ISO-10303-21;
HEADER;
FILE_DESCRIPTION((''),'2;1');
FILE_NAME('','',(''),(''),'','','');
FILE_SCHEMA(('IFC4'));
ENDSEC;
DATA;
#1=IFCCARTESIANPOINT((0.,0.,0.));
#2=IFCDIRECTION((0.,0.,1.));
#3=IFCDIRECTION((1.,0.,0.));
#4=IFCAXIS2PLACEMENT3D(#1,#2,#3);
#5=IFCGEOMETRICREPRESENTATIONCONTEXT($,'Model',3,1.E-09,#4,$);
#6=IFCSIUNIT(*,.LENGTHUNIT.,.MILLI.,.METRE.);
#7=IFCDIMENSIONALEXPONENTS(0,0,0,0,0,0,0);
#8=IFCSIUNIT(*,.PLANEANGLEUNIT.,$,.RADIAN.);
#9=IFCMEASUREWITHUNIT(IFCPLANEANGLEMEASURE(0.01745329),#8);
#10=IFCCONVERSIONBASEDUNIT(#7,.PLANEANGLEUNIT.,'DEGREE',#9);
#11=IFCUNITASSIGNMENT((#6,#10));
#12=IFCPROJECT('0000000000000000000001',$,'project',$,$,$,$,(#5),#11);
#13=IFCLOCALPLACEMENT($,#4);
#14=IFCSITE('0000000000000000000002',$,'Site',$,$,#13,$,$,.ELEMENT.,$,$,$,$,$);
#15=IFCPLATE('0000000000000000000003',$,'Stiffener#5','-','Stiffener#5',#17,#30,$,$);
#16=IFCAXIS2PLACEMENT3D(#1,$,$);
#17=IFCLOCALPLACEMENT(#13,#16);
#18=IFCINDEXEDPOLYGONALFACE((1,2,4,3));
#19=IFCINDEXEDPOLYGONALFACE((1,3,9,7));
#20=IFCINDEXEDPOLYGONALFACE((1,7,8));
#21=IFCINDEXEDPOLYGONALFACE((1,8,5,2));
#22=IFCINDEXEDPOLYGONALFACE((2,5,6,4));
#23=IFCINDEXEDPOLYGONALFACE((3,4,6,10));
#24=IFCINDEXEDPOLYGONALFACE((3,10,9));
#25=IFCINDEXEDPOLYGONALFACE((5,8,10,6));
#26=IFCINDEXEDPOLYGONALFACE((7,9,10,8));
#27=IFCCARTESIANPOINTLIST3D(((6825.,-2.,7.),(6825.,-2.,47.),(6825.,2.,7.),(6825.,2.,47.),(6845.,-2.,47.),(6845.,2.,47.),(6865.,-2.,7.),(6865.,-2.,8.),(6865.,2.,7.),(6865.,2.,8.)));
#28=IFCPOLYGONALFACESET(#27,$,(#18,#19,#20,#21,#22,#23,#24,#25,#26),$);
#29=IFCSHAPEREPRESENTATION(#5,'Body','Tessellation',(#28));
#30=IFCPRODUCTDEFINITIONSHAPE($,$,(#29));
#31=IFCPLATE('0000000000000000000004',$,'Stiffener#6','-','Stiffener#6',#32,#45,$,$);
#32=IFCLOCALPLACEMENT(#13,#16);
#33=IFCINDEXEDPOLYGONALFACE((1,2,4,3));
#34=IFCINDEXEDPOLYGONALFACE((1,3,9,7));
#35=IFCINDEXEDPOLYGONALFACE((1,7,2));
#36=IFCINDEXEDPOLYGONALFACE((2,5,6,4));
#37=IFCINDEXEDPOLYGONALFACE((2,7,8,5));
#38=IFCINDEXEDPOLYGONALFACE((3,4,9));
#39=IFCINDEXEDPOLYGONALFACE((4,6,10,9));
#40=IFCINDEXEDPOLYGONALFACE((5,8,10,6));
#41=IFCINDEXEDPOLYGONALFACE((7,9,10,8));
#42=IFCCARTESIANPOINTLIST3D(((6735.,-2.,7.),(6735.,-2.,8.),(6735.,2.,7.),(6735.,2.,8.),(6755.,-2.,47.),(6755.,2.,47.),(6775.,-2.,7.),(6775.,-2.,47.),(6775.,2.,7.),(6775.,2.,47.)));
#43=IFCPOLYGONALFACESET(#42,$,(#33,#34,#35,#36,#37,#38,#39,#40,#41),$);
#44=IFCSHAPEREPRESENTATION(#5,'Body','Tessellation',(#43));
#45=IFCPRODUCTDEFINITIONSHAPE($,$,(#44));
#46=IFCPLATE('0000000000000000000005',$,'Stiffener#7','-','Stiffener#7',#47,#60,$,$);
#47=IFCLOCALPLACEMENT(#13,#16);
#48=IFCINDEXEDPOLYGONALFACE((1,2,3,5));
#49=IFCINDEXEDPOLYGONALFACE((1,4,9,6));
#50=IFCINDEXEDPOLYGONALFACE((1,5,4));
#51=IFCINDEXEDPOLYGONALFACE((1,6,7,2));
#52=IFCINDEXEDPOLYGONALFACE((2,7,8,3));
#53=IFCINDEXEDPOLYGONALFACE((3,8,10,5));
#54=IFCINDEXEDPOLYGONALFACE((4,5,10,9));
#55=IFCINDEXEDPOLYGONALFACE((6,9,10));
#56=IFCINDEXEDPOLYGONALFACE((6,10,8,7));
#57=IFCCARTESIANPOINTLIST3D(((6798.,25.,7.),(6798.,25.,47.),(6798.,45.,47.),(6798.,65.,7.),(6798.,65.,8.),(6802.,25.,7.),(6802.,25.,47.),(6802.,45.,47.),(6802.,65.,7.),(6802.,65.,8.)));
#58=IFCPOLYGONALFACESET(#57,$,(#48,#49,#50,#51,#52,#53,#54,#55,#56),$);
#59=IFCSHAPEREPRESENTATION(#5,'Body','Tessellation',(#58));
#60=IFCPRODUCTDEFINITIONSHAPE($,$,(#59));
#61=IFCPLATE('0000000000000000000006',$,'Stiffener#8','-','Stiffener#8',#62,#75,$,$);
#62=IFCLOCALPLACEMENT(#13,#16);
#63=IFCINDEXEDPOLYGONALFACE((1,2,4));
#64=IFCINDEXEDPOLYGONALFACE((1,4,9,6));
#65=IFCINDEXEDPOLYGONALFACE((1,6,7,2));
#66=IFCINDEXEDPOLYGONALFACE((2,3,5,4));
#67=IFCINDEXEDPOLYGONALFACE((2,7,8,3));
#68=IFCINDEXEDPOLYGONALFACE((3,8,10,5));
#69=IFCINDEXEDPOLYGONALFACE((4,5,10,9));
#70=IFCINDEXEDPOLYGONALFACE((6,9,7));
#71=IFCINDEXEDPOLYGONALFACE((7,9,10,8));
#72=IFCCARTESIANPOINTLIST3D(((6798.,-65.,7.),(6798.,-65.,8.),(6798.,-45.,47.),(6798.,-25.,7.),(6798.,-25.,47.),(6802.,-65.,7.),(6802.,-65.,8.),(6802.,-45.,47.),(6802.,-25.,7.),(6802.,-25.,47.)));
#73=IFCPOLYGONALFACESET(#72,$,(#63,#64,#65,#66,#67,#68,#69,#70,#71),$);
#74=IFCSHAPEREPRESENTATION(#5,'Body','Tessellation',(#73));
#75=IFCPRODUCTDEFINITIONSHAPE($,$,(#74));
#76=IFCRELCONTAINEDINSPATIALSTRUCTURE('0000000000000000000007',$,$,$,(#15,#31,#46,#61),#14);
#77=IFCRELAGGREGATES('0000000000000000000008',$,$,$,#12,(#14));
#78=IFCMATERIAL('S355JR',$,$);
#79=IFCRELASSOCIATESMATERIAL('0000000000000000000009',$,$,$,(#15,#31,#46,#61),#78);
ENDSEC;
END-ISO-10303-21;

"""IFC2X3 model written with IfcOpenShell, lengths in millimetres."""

from ifc_helpers import new_model, entity, si_unit, converted_unit, frame, origin, origin_with_axes, place, context, project, spatial, polyline, outline, extrude, material, element, save


model = new_model("IFC2X3")

# Units and contexts
model_context = context("Model", 3, precision=1e-09, world=origin_with_axes())
ifc_project = project(units=[si_unit("LENGTHUNIT", "METRE", prefix="MILLI"), converted_unit("PLANEANGLEUNIT", "DEGREE", entity("IfcPlaneAngleMeasure", 0.01745329), si_unit("PLANEANGLEUNIT", "RADIAN"), dimensions=[0, 0, 0, 0, 0, 0, 0])], contexts=[model_context])

# Site
site_placement = place(None, origin_with_axes())
site = spatial("IfcSite", under=ifc_project, at=site_placement, Name="Site", CompositionType="ELEMENT")

# Shared definitions
ifc_material = material(Name="S355JR")

# Plates, openings
plate_1_placement = place(None, frame((6825.0, -2.0, 7.0), z_axis=(0.0, 1.0, 0.0), x_axis=(0.0, 0.0, 1.0)))
plate_1 = element("IfcPlate", 1, at=plate_1_placement, inside=site, material=ifc_material, Name="Stiffener#5", Description="-", ObjectType="Stiffener#5", context=model_context, shape_type="SweptSolid", body=[
    extrude(outline(polyline([(0.0, 0.0), (40.0, 0.0), (40.0, 40.0), (0.0, 40.0), (0.0, 0.0)])), origin_with_axes(), (0.0, 0.0, 1.0), 4.0),
])
opening_1_placement = place(plate_1_placement, frame((0.0, 0.0, 0.0), z_axis=(0.0, 0.0, 1.0), x_axis=(1.0, 0.0, 0.0)))
element("IfcOpeningElement", 2, at=opening_1_placement, cuts=plate_1, ObjectType="Opening", context=model_context, shape_type="SweptSolid", body=[
    extrude(outline(polyline([(40.0, 40.0), (1.0, 40.0), (40.0, 20.0), (40.0, 40.0)])), origin(), (0.0, 0.0, 1.0), 4.0),
])
plate_2_placement = place(None, frame((6775.0, -2.0, 7.0), z_axis=(0.0, 1.0, 0.0), x_axis=(-1.0, 0.0, 0.0)))
plate_2 = element("IfcPlate", 3, at=plate_2_placement, inside=site, material=ifc_material, Name="Stiffener#6", Description="-", ObjectType="Stiffener#6", context=model_context, shape_type="SweptSolid", body=[
    extrude(outline(polyline([(0.0, 0.0), (40.0, 0.0), (40.0, 40.0), (0.0, 40.0), (0.0, 0.0)])), origin_with_axes(), (0.0, 0.0, 1.0), 4.0),
])
opening_2_placement = place(plate_2_placement, frame((0.0, 0.0, 0.0), z_axis=(0.0, 0.0, 1.0), x_axis=(1.0, 0.0, 0.0)))
element("IfcOpeningElement", 4, at=opening_2_placement, cuts=plate_2, ObjectType="Opening", context=model_context, shape_type="SweptSolid", body=[
    extrude(outline(polyline([(40.0, 40.0), (20.0, 40.0), (40.0, 1.0), (40.0, 40.0)])), origin(), (0.0, 0.0, 1.0), 4.0),
])
plate_3_placement = place(None, frame((6802.0, 25.0, 7.0), z_axis=(-1.0, 0.0, 0.0), x_axis=(0.0, 0.0, 1.0)))
plate_3 = element("IfcPlate", 5, at=plate_3_placement, inside=site, material=ifc_material, Name="Stiffener#7", Description="-", ObjectType="Stiffener#7", context=model_context, shape_type="SweptSolid", body=[
    extrude(outline(polyline([(0.0, 0.0), (40.0, 0.0), (40.0, 40.0), (0.0, 40.0), (0.0, 0.0)])), origin_with_axes(), (0.0, 0.0, 1.0), 4.0),
])
opening_3_placement = place(plate_3_placement, frame((0.0, 0.0, 0.0), z_axis=(0.0, 0.0, 1.0), x_axis=(1.0, 0.0, 0.0)))
element("IfcOpeningElement", 6, at=opening_3_placement, cuts=plate_3, ObjectType="Opening", context=model_context, shape_type="SweptSolid", body=[
    extrude(outline(polyline([(40.0, 40.0), (1.0, 40.0), (40.0, 20.0), (40.0, 40.0)])), origin(), (0.0, 0.0, 1.0), 4.0),
])
plate_4_placement = place(None, frame((6802.0, -25.0, 7.0), z_axis=(-1.0, 0.0, 0.0), x_axis=(0.0, -1.0, 0.0)))
plate_4 = element("IfcPlate", 7, at=plate_4_placement, inside=site, material=ifc_material, Name="Stiffener#8", Description="-", ObjectType="Stiffener#8", context=model_context, shape_type="SweptSolid", body=[
    extrude(outline(polyline([(0.0, 0.0), (40.0, 0.0), (40.0, 40.0), (0.0, 40.0), (0.0, 0.0)])), origin_with_axes(), (0.0, 0.0, 1.0), 4.0),
])
opening_4_placement = place(plate_4_placement, frame((0.0, 0.0, 0.0), z_axis=(0.0, 0.0, 1.0), x_axis=(1.0, 0.0, 0.0)))
element("IfcOpeningElement", 8, at=opening_4_placement, cuts=plate_4, ObjectType="Opening", context=model_context, shape_type="SweptSolid", body=[
    extrude(outline(polyline([(40.0, 40.0), (20.0, 40.0), (40.0, 1.0), (40.0, 40.0)])), origin(), (0.0, 0.0, 1.0), 4.0),
])

save(model, "model.ifc")
